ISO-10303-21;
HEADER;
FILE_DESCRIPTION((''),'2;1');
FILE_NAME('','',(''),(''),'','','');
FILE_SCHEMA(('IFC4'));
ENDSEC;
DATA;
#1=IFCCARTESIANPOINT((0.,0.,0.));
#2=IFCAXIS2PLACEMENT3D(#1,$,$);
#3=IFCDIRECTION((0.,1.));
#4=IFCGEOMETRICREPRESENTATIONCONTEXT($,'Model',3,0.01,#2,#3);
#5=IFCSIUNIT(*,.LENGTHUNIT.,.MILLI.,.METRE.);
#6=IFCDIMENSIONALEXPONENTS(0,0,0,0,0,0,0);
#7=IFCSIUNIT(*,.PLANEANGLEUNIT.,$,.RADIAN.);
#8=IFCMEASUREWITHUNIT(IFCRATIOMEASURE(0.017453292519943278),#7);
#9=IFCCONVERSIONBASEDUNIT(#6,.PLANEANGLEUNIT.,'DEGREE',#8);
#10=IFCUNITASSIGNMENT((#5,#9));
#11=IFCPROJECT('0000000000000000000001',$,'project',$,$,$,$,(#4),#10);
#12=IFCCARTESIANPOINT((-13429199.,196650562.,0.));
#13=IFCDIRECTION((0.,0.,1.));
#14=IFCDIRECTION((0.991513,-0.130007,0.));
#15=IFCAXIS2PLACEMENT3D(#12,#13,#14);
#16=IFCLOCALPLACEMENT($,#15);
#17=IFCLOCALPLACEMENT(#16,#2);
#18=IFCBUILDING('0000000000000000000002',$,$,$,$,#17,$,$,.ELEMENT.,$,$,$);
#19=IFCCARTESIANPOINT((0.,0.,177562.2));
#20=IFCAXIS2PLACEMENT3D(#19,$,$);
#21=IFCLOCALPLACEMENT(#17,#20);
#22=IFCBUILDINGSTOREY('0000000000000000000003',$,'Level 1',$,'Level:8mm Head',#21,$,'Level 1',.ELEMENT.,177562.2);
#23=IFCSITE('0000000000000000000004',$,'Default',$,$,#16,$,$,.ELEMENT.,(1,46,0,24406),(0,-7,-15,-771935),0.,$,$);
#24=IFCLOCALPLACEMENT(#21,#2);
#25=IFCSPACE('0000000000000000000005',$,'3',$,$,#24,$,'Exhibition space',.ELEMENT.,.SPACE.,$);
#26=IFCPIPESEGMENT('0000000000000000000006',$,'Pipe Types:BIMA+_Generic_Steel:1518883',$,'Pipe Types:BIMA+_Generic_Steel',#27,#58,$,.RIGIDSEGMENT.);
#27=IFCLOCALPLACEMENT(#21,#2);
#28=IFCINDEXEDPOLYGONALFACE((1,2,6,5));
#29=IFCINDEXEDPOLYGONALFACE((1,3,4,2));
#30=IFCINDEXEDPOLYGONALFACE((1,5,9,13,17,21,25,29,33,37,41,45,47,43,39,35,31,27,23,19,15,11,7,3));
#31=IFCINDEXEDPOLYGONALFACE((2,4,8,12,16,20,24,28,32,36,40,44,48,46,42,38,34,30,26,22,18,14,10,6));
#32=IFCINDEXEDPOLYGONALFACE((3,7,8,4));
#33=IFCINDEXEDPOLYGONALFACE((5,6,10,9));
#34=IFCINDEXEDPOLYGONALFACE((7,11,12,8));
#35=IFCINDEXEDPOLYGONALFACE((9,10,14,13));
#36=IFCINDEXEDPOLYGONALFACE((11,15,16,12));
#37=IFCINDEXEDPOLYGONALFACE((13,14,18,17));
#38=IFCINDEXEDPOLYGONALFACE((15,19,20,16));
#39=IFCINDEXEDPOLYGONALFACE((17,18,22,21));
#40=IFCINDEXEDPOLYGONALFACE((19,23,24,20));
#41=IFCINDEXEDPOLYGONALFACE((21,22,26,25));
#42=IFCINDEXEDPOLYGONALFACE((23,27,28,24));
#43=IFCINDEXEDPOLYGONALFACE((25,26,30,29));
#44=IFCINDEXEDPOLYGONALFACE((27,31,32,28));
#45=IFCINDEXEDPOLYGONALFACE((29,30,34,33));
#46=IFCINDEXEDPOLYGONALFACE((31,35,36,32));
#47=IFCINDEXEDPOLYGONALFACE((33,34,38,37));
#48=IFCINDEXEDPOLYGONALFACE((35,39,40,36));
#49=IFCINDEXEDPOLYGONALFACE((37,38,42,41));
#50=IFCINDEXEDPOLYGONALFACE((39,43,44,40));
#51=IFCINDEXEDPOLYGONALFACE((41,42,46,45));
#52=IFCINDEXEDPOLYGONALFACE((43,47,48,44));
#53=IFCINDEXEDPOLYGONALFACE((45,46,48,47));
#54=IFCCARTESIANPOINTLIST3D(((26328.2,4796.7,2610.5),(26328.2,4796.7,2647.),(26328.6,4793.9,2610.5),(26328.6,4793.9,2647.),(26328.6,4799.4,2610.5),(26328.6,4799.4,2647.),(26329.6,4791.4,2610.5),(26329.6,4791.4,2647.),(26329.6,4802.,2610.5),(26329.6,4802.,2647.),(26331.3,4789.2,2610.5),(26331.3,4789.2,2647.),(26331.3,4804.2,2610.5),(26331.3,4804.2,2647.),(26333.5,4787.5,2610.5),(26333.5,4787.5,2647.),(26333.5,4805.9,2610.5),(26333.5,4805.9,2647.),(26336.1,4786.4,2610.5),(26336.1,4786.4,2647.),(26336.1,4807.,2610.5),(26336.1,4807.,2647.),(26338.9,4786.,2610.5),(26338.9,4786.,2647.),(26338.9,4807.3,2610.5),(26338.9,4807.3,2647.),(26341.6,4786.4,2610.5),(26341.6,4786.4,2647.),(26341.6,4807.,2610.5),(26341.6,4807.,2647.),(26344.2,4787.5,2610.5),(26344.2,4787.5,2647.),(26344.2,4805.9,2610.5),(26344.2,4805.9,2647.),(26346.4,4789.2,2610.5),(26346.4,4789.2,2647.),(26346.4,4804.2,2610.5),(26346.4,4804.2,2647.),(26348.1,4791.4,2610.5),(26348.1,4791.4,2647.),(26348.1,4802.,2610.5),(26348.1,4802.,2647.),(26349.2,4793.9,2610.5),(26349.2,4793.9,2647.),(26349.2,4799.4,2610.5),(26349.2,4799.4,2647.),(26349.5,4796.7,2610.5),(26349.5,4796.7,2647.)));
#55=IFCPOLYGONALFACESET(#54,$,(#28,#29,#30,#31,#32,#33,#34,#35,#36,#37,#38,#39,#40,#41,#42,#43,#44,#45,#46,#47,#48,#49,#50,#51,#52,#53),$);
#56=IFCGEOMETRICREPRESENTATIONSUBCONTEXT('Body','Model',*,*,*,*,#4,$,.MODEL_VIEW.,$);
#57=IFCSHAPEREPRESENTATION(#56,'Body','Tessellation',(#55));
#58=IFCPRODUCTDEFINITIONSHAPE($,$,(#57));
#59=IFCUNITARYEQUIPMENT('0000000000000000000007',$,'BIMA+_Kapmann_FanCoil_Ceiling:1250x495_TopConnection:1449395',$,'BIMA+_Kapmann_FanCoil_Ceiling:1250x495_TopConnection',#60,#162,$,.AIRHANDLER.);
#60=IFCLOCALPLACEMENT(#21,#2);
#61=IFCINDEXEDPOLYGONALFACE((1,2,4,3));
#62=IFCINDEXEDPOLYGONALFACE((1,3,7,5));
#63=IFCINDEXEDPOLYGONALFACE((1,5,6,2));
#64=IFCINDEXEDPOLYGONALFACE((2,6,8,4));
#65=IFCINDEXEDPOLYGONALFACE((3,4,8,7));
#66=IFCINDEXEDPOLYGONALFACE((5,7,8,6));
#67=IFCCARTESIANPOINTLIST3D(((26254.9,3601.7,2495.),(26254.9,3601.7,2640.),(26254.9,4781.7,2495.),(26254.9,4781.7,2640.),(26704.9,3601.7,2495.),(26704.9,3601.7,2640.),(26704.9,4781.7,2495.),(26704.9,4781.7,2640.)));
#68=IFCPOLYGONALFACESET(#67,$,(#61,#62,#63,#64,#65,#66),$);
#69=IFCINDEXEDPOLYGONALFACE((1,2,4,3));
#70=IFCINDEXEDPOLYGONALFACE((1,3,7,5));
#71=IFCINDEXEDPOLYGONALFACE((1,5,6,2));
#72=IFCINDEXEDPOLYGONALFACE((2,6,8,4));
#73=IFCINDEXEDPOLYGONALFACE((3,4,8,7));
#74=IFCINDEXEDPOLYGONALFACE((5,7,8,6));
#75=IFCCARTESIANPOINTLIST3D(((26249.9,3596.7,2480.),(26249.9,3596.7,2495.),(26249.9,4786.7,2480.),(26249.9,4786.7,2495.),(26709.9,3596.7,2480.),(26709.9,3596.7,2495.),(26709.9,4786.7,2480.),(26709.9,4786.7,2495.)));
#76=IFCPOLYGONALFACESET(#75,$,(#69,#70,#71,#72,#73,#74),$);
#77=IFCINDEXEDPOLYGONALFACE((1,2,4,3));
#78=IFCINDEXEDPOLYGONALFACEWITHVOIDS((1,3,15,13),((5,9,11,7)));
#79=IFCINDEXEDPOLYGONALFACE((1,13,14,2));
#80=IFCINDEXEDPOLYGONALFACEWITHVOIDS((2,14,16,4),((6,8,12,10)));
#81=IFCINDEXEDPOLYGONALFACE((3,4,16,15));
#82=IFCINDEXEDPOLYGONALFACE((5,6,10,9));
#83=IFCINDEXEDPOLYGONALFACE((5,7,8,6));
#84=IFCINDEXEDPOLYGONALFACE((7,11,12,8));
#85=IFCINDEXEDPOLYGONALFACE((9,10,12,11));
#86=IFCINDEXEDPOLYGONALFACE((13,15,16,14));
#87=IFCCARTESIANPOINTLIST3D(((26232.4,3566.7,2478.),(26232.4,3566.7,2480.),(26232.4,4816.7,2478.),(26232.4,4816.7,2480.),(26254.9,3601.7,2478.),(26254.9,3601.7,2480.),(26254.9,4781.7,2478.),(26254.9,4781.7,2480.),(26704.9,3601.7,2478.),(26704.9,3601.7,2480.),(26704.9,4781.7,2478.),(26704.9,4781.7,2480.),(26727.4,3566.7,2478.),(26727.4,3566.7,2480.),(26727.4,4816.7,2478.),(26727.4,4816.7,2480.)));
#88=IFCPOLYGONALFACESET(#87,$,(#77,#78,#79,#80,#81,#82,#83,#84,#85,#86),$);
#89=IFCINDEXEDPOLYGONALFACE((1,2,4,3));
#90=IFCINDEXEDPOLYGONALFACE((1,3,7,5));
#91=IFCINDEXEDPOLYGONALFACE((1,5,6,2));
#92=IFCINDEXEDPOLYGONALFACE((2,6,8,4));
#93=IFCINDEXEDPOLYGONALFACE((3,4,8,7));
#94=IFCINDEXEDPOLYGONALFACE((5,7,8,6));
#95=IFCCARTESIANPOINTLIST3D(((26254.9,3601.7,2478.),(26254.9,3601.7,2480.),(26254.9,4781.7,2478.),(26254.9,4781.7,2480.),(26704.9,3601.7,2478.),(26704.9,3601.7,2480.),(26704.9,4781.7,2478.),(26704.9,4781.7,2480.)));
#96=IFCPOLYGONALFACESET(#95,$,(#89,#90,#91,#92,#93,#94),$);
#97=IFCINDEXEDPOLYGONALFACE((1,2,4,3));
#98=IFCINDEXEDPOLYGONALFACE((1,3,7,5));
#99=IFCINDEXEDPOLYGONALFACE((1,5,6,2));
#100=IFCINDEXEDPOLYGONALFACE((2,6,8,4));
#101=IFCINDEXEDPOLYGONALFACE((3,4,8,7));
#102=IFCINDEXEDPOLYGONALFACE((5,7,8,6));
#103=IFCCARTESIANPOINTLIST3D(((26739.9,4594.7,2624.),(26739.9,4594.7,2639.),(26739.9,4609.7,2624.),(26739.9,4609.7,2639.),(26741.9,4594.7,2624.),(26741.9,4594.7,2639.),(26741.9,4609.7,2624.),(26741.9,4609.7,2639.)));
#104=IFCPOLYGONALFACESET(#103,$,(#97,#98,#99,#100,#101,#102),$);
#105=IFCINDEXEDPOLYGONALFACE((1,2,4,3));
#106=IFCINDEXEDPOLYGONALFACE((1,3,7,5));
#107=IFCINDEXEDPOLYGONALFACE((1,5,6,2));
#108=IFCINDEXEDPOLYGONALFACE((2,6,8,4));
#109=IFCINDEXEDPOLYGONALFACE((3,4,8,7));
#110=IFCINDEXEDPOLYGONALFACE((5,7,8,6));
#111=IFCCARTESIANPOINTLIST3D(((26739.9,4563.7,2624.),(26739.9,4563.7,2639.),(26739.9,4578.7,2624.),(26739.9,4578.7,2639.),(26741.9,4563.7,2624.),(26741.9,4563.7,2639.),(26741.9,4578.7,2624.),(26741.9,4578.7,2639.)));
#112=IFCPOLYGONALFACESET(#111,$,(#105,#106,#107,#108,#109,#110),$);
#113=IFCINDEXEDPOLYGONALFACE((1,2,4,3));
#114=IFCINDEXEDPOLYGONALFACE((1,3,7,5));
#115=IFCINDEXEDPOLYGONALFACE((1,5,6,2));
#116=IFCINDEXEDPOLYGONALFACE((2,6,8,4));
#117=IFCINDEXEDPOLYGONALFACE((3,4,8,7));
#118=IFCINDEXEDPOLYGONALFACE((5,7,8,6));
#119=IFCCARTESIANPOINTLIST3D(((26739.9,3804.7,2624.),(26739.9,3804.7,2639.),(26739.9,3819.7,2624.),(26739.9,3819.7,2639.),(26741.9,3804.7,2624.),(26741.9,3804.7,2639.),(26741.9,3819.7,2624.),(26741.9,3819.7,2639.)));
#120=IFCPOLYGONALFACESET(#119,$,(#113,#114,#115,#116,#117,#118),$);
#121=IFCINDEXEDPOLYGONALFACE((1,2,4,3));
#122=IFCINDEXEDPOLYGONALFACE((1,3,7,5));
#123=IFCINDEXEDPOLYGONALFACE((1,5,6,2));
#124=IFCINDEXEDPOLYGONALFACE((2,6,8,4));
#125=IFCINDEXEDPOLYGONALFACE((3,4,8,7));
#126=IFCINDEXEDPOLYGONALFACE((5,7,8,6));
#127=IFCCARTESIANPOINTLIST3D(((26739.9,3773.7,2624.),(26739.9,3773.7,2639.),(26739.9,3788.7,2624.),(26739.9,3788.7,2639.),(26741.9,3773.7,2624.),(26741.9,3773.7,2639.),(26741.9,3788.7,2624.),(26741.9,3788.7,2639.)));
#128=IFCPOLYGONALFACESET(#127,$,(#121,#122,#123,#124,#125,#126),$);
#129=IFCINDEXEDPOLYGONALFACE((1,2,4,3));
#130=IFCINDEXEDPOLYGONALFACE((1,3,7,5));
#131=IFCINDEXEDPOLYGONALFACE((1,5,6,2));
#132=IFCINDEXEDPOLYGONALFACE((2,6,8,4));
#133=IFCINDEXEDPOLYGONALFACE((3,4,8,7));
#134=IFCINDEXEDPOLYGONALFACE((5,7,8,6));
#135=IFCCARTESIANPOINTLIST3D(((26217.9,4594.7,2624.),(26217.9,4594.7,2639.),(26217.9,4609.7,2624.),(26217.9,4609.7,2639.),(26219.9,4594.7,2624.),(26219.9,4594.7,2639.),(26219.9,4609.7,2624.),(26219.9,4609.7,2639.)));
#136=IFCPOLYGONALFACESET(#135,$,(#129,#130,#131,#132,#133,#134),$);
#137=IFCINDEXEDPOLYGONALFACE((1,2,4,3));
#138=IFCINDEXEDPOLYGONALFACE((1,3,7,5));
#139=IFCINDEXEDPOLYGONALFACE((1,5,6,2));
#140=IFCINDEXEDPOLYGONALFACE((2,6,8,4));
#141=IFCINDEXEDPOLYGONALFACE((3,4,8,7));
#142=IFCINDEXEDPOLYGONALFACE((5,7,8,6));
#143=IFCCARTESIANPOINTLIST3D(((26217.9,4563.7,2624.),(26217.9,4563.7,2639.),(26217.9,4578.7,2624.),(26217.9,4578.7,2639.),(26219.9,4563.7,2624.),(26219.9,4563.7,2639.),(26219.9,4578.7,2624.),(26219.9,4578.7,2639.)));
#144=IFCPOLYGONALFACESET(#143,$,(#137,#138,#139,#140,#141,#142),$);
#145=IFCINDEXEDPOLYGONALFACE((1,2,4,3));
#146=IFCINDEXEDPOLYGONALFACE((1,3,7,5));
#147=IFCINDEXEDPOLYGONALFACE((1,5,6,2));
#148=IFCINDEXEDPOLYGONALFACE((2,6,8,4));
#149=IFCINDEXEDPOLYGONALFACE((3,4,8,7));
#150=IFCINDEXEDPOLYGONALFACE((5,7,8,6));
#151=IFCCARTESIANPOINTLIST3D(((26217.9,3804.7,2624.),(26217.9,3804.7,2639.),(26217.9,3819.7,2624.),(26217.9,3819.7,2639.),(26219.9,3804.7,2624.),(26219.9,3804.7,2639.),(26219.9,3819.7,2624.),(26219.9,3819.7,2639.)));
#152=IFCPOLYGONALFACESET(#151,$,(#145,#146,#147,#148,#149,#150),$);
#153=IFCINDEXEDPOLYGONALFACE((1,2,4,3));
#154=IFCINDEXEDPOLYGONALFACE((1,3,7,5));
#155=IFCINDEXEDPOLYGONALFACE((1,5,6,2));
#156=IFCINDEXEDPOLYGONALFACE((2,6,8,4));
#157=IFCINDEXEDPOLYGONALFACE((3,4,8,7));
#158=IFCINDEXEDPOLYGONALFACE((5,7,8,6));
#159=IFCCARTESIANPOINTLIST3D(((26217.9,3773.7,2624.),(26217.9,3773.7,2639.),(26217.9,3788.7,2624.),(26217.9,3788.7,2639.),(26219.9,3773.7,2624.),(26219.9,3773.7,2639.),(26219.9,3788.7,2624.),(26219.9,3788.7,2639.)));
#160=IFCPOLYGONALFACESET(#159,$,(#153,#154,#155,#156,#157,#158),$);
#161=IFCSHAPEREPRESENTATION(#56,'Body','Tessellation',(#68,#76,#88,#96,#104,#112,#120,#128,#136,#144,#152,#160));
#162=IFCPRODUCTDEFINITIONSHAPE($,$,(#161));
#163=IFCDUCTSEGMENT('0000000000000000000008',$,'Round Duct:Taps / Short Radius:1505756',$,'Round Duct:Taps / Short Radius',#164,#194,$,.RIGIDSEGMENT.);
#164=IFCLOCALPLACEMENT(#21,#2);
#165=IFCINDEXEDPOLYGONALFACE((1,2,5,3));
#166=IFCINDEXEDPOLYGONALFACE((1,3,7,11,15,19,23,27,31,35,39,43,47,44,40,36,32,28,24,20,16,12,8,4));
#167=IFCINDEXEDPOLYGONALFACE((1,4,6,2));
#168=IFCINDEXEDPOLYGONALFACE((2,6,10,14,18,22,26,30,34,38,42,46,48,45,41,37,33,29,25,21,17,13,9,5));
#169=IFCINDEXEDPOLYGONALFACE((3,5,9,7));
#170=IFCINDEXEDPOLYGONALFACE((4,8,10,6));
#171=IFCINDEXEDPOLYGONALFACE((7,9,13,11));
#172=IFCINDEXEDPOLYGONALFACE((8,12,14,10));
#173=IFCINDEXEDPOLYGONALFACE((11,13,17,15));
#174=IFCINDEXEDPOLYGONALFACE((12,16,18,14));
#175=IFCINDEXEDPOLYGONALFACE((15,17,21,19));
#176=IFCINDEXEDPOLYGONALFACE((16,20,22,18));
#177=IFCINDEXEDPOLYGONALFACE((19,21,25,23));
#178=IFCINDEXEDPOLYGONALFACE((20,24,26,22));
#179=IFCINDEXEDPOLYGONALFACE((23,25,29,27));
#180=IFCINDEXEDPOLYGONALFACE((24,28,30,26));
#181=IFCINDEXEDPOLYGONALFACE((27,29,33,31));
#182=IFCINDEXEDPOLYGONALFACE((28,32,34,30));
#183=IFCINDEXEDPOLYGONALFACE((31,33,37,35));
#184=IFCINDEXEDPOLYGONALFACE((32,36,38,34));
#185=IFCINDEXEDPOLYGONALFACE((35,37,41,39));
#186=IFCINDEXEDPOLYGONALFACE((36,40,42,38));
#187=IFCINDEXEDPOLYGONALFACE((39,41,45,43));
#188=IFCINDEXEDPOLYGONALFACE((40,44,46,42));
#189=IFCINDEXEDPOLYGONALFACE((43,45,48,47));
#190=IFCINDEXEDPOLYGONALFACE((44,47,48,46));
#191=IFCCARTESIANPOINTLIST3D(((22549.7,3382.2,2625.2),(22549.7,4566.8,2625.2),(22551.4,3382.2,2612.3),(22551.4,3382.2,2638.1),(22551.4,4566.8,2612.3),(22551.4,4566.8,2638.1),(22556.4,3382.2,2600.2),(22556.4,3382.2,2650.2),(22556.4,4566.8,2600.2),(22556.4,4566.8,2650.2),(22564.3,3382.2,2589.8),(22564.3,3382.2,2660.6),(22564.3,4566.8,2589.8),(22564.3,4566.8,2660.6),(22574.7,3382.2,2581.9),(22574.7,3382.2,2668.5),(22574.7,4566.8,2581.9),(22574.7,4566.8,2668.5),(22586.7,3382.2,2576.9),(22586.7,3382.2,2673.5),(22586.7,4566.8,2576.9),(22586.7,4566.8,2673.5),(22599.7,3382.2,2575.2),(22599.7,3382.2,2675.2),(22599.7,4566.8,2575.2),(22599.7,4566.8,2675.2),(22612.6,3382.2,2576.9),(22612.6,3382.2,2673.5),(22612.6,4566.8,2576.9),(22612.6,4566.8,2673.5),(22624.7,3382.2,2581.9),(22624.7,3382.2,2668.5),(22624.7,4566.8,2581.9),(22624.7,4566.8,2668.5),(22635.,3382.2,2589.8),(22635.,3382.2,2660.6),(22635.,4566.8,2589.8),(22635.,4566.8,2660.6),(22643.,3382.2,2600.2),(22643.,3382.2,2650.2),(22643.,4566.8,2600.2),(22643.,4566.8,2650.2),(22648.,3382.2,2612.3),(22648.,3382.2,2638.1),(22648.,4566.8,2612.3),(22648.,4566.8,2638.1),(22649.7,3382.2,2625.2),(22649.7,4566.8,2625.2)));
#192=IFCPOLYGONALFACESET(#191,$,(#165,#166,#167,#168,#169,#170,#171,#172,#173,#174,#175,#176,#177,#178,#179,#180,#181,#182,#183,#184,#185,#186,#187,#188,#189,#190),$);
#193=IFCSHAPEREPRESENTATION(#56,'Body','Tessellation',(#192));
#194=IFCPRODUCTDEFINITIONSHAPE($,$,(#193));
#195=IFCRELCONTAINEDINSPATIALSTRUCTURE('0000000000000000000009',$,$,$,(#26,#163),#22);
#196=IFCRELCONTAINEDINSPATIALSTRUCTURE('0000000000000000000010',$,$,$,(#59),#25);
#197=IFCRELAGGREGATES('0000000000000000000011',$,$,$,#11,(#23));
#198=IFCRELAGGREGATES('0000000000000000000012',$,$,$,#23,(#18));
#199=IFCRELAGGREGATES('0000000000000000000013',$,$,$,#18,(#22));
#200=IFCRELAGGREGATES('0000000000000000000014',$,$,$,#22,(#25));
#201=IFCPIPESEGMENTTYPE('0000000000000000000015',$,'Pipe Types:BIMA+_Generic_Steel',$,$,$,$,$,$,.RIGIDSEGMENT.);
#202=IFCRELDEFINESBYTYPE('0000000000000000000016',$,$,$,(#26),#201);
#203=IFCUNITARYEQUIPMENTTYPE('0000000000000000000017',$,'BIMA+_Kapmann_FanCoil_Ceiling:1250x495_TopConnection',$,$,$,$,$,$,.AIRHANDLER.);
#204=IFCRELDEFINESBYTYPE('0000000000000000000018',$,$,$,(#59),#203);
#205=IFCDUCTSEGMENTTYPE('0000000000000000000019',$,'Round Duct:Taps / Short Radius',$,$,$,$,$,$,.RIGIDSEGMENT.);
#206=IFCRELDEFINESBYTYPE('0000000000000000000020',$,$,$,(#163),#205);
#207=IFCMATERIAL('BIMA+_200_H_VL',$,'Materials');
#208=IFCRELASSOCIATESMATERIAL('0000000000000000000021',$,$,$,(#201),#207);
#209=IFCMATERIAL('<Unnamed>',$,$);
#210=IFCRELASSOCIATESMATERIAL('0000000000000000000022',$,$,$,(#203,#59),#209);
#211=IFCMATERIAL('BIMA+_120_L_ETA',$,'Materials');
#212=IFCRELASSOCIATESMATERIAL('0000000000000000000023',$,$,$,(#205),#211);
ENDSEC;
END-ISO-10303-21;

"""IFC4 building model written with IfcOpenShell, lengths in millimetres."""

from ifc_helpers import new_model, entity, si_unit, converted_unit, direction, frame, origin, place, context, subcontext, project, spatial, arc, indexed_curve, outline, extrude, source, transform, mapped, material, type_object, type_shapes, element, save


model = new_model("IFC4")

# Units and contexts
model_context = context("Model", 3, precision=0.01, world=origin(), true_north=direction((0.0, 1.0)))
body_context = subcontext(model_context, "Body", "Model", "MODEL_VIEW")
ifc_project = project(units=[si_unit("LENGTHUNIT", "METRE", prefix="MILLI"), converted_unit("PLANEANGLEUNIT", "DEGREE", entity("IfcRatioMeasure", 0.017453292519943278), si_unit("PLANEANGLEUNIT", "RADIAN"), dimensions=[0, 0, 0, 0, 0, 0, 0])], contexts=[model_context])

# Site, building, storey
site_placement = place(None, frame((-13429199.0, 196650562.0, 0.0), z_axis=(0.0, 0.0, 1.0), x_axis=(0.991513, -0.130007, 0.0)))
site = spatial("IfcSite", under=ifc_project, at=site_placement, Name="Default", CompositionType="ELEMENT", RefLatitude=(1, 46, 0, 24406), RefLongitude=(0, -7, -15, -771935), RefElevation=0.0)
building_placement = place(site_placement, origin())
building = spatial("IfcBuilding", under=site, at=building_placement, CompositionType="ELEMENT")
storey_placement = place(building_placement, frame((0.0, 0.0, 177562.2)))
storey = spatial("IfcBuildingStorey", under=building, at=storey_placement, Name="Level 1", ObjectType="Level:8mm Head", LongName="Level 1", CompositionType="ELEMENT", Elevation=177562.2)

# Pipe segment
ifc_material_1 = material(Name="BIMA+_200_H_VL", Category="Materials")
pipe_segment_type_1 = type_object("IfcPipeSegmentType", Name="Pipe Types:BIMA+_Generic_Steel", PredefinedType="RIGIDSEGMENT", material=ifc_material_1)
pipe_segment_1_placement = place(storey_placement, frame((26326.6, 4784.4, 2610.5)))
element("IfcPipeSegment", 1, at=pipe_segment_1_placement, inside=storey, type_object=pipe_segment_type_1, Name="Pipe Types:BIMA+_Generic_Steel:1518883", ObjectType="Pipe Types:BIMA+_Generic_Steel", PredefinedType="RIGIDSEGMENT", context=body_context, shape_type="SweptSolid", body=[
    extrude(outline(indexed_curve([(10.7, 0.0), (7.5, 7.5), (0.0, 10.6), (-7.5, 7.5), (-10.7, 0.0), (-7.5, -7.5), (0.0, -10.6), (7.5, -7.5)], segments=[arc(1, 2, 3), arc(3, 4, 5), arc(5, 6, 7), arc(7, 8, 1)], self_intersect=False)), frame((12.2, 12.2, 0.0), z_axis=(0.0, 0.0, 1.0), x_axis=(-1.0, 0.0, 0.0)), (0.0, 0.0, 1.0), 36.5),
])

# Shared definitions
space_placement = place(storey_placement, origin())
space = spatial("IfcSpace", under=storey, at=space_placement, Name="3", LongName="Exhibition space", CompositionType="ELEMENT", PredefinedType="SPACE")

# Unitary equipment
ifc_material_2 = material(Name="<Unnamed>")
unitary_equipment_type = type_object("IfcUnitaryEquipmentType", Name="BIMA+_Kapmann_FanCoil_Ceiling:1250x495_TopConnection", PredefinedType="AIRHANDLER", material=ifc_material_2)
shared_shape = source(origin(), body_context, "Body", "SweptSolid", [
    extrude(outline(indexed_curve([(-590.0, -225.0), (590.0, -225.0), (590.0, 225.0), (-590.0, 225.0), (-590.0, -225.0)], self_intersect=False)), frame((0.0, 0.0, 15.0)), (0.0, 0.0, 1.0), 145.0),
    extrude(outline(indexed_curve([(-595.0, -230.0), (595.0, -230.0), (595.0, 230.0), (-595.0, 230.0), (-595.0, -230.0)], self_intersect=False)), frame((0.0, 0.0, 0.0), z_axis=(0.0, 0.0, 1.0), x_axis=(-1.0, 0.0, 0.0)), (0.0, 0.0, 1.0), 15.0),
    extrude(outline(indexed_curve([(-625.0, -247.5), (625.0, -247.5), (625.0, 247.5), (-625.0, 247.5), (-625.0, -247.5)], self_intersect=False), holes=[indexed_curve([(-590.0, -225.0), (-590.0, 225.0), (590.0, 225.0), (590.0, -225.0), (-590.0, -225.0)], self_intersect=False)]), frame((0.0, 0.0, -2.0), z_axis=(0.0, 0.0, 1.0), x_axis=(-1.0, 0.0, 0.0)), (0.0, 0.0, 1.0), 2.0),
    extrude(outline(indexed_curve([(-590.0, -225.0), (590.0, -225.0), (590.0, 225.0), (-590.0, 225.0), (-590.0, -225.0)], self_intersect=False)), frame((0.0, 0.0, -2.0), z_axis=(0.0, 0.0, 1.0), x_axis=(-1.0, 0.0, 0.0)), (0.0, 0.0, 1.0), 2.0),
    extrude(outline(indexed_curve([(-1.0, -7.5), (1.0, -7.5), (1.0, 7.5), (-1.0, 7.5), (-1.0, -7.5)], self_intersect=False)), frame((-410.5, 261.0, 144.0), z_axis=(0.0, 0.0, 1.0), x_axis=(0.0, -1.0, 0.0)), (0.0, 0.0, 1.0), 15.0),
    extrude(outline(indexed_curve([(-1.0, -7.5), (1.0, -7.5), (1.0, 7.5), (-1.0, 7.5), (-1.0, -7.5)], self_intersect=False)), frame((-379.5, 261.0, 144.0), z_axis=(0.0, 0.0, 1.0), x_axis=(0.0, -1.0, 0.0)), (0.0, 0.0, 1.0), 15.0),
    extrude(outline(indexed_curve([(-1.0, -7.5), (1.0, -7.5), (1.0, 7.5), (-1.0, 7.5), (-1.0, -7.5)], self_intersect=False)), frame((379.5, 261.0, 144.0), z_axis=(0.0, 0.0, 1.0), x_axis=(0.0, -1.0, 0.0)), (0.0, 0.0, 1.0), 15.0),
    extrude(outline(indexed_curve([(-1.0, -7.5), (1.0, -7.5), (1.0, 7.5), (-1.0, 7.5), (-1.0, -7.5)], self_intersect=False)), frame((410.5, 261.0, 144.0), z_axis=(0.0, 0.0, 1.0), x_axis=(0.0, -1.0, 0.0)), (0.0, 0.0, 1.0), 15.0),
    extrude(outline(indexed_curve([(-1.0, -7.5), (1.0, -7.5), (1.0, 7.5), (-1.0, 7.5), (-1.0, -7.5)], self_intersect=False)), frame((-410.5, -261.0, 144.0), z_axis=(0.0, 0.0, 1.0), x_axis=(0.0, -1.0, 0.0)), (0.0, 0.0, 1.0), 15.0),
    extrude(outline(indexed_curve([(-1.0, -7.5), (1.0, -7.5), (1.0, 7.5), (-1.0, 7.5), (-1.0, -7.5)], self_intersect=False)), frame((-379.5, -261.0, 144.0), z_axis=(0.0, 0.0, 1.0), x_axis=(0.0, -1.0, 0.0)), (0.0, 0.0, 1.0), 15.0),
    extrude(outline(indexed_curve([(-1.0, -7.5), (1.0, -7.5), (1.0, 7.5), (-1.0, 7.5), (-1.0, -7.5)], self_intersect=False)), frame((379.5, -261.0, 144.0), z_axis=(0.0, 0.0, 1.0), x_axis=(0.0, -1.0, 0.0)), (0.0, 0.0, 1.0), 15.0),
    extrude(outline(indexed_curve([(-1.0, -7.5), (1.0, -7.5), (1.0, 7.5), (-1.0, 7.5), (-1.0, -7.5)], self_intersect=False)), frame((410.5, -261.0, 144.0), z_axis=(0.0, 0.0, 1.0), x_axis=(0.0, -1.0, 0.0)), (0.0, 0.0, 1.0), 15.0),
])
type_shapes(unitary_equipment_type, [shared_shape])
unitary_equipment_placement = place(space_placement, frame((26479.9, 4191.7, 2480.0), z_axis=(0.0, 0.0, 1.0), x_axis=(0.0, -1.0, 0.0)))
element("IfcUnitaryEquipment", 2, at=unitary_equipment_placement, inside=space, type_object=unitary_equipment_type, material=ifc_material_2, Name="BIMA+_Kapmann_FanCoil_Ceiling:1250x495_TopConnection:1449395", ObjectType="BIMA+_Kapmann_FanCoil_Ceiling:1250x495_TopConnection", PredefinedType="AIRHANDLER", context=body_context, shape_type="MappedRepresentation", body=[
    mapped(shared_shape, transform((0.0, 0.0, 0.0), scale=1.0)),
])

# Duct segment
ifc_material_3 = material(Name="BIMA+_120_L_ETA", Category="Materials")
duct_segment_type = type_object("IfcDuctSegmentType", Name="Round Duct:Taps / Short Radius", PredefinedType="RIGIDSEGMENT", material=ifc_material_3)
duct_segment_1_placement = place(storey_placement, frame((22548.1, 3382.2, 2573.6)))
element("IfcDuctSegment", 3, at=duct_segment_1_placement, inside=storey, type_object=duct_segment_type, Name="Round Duct:Taps / Short Radius:1505756", ObjectType="Round Duct:Taps / Short Radius", PredefinedType="RIGIDSEGMENT", context=body_context, shape_type="SweptSolid", body=[
    extrude(outline(indexed_curve([(50.0, 0.0), (35.4, 35.4), (0.0, 50.0), (-35.4, 35.4), (-50.0, 0.0), (-35.4, -35.4), (0.0, -50.0), (35.4, -35.4)], segments=[arc(1, 2, 3), arc(3, 4, 5), arc(5, 6, 7), arc(7, 8, 1)], self_intersect=False)), frame((51.6, 0.0, 51.6), z_axis=(0.0, 1.0, 0.0), x_axis=(-1.0, 0.0, 0.0)), (0.0, 0.0, 1.0), 1184.6),
])

save(model, "model.ifc")
